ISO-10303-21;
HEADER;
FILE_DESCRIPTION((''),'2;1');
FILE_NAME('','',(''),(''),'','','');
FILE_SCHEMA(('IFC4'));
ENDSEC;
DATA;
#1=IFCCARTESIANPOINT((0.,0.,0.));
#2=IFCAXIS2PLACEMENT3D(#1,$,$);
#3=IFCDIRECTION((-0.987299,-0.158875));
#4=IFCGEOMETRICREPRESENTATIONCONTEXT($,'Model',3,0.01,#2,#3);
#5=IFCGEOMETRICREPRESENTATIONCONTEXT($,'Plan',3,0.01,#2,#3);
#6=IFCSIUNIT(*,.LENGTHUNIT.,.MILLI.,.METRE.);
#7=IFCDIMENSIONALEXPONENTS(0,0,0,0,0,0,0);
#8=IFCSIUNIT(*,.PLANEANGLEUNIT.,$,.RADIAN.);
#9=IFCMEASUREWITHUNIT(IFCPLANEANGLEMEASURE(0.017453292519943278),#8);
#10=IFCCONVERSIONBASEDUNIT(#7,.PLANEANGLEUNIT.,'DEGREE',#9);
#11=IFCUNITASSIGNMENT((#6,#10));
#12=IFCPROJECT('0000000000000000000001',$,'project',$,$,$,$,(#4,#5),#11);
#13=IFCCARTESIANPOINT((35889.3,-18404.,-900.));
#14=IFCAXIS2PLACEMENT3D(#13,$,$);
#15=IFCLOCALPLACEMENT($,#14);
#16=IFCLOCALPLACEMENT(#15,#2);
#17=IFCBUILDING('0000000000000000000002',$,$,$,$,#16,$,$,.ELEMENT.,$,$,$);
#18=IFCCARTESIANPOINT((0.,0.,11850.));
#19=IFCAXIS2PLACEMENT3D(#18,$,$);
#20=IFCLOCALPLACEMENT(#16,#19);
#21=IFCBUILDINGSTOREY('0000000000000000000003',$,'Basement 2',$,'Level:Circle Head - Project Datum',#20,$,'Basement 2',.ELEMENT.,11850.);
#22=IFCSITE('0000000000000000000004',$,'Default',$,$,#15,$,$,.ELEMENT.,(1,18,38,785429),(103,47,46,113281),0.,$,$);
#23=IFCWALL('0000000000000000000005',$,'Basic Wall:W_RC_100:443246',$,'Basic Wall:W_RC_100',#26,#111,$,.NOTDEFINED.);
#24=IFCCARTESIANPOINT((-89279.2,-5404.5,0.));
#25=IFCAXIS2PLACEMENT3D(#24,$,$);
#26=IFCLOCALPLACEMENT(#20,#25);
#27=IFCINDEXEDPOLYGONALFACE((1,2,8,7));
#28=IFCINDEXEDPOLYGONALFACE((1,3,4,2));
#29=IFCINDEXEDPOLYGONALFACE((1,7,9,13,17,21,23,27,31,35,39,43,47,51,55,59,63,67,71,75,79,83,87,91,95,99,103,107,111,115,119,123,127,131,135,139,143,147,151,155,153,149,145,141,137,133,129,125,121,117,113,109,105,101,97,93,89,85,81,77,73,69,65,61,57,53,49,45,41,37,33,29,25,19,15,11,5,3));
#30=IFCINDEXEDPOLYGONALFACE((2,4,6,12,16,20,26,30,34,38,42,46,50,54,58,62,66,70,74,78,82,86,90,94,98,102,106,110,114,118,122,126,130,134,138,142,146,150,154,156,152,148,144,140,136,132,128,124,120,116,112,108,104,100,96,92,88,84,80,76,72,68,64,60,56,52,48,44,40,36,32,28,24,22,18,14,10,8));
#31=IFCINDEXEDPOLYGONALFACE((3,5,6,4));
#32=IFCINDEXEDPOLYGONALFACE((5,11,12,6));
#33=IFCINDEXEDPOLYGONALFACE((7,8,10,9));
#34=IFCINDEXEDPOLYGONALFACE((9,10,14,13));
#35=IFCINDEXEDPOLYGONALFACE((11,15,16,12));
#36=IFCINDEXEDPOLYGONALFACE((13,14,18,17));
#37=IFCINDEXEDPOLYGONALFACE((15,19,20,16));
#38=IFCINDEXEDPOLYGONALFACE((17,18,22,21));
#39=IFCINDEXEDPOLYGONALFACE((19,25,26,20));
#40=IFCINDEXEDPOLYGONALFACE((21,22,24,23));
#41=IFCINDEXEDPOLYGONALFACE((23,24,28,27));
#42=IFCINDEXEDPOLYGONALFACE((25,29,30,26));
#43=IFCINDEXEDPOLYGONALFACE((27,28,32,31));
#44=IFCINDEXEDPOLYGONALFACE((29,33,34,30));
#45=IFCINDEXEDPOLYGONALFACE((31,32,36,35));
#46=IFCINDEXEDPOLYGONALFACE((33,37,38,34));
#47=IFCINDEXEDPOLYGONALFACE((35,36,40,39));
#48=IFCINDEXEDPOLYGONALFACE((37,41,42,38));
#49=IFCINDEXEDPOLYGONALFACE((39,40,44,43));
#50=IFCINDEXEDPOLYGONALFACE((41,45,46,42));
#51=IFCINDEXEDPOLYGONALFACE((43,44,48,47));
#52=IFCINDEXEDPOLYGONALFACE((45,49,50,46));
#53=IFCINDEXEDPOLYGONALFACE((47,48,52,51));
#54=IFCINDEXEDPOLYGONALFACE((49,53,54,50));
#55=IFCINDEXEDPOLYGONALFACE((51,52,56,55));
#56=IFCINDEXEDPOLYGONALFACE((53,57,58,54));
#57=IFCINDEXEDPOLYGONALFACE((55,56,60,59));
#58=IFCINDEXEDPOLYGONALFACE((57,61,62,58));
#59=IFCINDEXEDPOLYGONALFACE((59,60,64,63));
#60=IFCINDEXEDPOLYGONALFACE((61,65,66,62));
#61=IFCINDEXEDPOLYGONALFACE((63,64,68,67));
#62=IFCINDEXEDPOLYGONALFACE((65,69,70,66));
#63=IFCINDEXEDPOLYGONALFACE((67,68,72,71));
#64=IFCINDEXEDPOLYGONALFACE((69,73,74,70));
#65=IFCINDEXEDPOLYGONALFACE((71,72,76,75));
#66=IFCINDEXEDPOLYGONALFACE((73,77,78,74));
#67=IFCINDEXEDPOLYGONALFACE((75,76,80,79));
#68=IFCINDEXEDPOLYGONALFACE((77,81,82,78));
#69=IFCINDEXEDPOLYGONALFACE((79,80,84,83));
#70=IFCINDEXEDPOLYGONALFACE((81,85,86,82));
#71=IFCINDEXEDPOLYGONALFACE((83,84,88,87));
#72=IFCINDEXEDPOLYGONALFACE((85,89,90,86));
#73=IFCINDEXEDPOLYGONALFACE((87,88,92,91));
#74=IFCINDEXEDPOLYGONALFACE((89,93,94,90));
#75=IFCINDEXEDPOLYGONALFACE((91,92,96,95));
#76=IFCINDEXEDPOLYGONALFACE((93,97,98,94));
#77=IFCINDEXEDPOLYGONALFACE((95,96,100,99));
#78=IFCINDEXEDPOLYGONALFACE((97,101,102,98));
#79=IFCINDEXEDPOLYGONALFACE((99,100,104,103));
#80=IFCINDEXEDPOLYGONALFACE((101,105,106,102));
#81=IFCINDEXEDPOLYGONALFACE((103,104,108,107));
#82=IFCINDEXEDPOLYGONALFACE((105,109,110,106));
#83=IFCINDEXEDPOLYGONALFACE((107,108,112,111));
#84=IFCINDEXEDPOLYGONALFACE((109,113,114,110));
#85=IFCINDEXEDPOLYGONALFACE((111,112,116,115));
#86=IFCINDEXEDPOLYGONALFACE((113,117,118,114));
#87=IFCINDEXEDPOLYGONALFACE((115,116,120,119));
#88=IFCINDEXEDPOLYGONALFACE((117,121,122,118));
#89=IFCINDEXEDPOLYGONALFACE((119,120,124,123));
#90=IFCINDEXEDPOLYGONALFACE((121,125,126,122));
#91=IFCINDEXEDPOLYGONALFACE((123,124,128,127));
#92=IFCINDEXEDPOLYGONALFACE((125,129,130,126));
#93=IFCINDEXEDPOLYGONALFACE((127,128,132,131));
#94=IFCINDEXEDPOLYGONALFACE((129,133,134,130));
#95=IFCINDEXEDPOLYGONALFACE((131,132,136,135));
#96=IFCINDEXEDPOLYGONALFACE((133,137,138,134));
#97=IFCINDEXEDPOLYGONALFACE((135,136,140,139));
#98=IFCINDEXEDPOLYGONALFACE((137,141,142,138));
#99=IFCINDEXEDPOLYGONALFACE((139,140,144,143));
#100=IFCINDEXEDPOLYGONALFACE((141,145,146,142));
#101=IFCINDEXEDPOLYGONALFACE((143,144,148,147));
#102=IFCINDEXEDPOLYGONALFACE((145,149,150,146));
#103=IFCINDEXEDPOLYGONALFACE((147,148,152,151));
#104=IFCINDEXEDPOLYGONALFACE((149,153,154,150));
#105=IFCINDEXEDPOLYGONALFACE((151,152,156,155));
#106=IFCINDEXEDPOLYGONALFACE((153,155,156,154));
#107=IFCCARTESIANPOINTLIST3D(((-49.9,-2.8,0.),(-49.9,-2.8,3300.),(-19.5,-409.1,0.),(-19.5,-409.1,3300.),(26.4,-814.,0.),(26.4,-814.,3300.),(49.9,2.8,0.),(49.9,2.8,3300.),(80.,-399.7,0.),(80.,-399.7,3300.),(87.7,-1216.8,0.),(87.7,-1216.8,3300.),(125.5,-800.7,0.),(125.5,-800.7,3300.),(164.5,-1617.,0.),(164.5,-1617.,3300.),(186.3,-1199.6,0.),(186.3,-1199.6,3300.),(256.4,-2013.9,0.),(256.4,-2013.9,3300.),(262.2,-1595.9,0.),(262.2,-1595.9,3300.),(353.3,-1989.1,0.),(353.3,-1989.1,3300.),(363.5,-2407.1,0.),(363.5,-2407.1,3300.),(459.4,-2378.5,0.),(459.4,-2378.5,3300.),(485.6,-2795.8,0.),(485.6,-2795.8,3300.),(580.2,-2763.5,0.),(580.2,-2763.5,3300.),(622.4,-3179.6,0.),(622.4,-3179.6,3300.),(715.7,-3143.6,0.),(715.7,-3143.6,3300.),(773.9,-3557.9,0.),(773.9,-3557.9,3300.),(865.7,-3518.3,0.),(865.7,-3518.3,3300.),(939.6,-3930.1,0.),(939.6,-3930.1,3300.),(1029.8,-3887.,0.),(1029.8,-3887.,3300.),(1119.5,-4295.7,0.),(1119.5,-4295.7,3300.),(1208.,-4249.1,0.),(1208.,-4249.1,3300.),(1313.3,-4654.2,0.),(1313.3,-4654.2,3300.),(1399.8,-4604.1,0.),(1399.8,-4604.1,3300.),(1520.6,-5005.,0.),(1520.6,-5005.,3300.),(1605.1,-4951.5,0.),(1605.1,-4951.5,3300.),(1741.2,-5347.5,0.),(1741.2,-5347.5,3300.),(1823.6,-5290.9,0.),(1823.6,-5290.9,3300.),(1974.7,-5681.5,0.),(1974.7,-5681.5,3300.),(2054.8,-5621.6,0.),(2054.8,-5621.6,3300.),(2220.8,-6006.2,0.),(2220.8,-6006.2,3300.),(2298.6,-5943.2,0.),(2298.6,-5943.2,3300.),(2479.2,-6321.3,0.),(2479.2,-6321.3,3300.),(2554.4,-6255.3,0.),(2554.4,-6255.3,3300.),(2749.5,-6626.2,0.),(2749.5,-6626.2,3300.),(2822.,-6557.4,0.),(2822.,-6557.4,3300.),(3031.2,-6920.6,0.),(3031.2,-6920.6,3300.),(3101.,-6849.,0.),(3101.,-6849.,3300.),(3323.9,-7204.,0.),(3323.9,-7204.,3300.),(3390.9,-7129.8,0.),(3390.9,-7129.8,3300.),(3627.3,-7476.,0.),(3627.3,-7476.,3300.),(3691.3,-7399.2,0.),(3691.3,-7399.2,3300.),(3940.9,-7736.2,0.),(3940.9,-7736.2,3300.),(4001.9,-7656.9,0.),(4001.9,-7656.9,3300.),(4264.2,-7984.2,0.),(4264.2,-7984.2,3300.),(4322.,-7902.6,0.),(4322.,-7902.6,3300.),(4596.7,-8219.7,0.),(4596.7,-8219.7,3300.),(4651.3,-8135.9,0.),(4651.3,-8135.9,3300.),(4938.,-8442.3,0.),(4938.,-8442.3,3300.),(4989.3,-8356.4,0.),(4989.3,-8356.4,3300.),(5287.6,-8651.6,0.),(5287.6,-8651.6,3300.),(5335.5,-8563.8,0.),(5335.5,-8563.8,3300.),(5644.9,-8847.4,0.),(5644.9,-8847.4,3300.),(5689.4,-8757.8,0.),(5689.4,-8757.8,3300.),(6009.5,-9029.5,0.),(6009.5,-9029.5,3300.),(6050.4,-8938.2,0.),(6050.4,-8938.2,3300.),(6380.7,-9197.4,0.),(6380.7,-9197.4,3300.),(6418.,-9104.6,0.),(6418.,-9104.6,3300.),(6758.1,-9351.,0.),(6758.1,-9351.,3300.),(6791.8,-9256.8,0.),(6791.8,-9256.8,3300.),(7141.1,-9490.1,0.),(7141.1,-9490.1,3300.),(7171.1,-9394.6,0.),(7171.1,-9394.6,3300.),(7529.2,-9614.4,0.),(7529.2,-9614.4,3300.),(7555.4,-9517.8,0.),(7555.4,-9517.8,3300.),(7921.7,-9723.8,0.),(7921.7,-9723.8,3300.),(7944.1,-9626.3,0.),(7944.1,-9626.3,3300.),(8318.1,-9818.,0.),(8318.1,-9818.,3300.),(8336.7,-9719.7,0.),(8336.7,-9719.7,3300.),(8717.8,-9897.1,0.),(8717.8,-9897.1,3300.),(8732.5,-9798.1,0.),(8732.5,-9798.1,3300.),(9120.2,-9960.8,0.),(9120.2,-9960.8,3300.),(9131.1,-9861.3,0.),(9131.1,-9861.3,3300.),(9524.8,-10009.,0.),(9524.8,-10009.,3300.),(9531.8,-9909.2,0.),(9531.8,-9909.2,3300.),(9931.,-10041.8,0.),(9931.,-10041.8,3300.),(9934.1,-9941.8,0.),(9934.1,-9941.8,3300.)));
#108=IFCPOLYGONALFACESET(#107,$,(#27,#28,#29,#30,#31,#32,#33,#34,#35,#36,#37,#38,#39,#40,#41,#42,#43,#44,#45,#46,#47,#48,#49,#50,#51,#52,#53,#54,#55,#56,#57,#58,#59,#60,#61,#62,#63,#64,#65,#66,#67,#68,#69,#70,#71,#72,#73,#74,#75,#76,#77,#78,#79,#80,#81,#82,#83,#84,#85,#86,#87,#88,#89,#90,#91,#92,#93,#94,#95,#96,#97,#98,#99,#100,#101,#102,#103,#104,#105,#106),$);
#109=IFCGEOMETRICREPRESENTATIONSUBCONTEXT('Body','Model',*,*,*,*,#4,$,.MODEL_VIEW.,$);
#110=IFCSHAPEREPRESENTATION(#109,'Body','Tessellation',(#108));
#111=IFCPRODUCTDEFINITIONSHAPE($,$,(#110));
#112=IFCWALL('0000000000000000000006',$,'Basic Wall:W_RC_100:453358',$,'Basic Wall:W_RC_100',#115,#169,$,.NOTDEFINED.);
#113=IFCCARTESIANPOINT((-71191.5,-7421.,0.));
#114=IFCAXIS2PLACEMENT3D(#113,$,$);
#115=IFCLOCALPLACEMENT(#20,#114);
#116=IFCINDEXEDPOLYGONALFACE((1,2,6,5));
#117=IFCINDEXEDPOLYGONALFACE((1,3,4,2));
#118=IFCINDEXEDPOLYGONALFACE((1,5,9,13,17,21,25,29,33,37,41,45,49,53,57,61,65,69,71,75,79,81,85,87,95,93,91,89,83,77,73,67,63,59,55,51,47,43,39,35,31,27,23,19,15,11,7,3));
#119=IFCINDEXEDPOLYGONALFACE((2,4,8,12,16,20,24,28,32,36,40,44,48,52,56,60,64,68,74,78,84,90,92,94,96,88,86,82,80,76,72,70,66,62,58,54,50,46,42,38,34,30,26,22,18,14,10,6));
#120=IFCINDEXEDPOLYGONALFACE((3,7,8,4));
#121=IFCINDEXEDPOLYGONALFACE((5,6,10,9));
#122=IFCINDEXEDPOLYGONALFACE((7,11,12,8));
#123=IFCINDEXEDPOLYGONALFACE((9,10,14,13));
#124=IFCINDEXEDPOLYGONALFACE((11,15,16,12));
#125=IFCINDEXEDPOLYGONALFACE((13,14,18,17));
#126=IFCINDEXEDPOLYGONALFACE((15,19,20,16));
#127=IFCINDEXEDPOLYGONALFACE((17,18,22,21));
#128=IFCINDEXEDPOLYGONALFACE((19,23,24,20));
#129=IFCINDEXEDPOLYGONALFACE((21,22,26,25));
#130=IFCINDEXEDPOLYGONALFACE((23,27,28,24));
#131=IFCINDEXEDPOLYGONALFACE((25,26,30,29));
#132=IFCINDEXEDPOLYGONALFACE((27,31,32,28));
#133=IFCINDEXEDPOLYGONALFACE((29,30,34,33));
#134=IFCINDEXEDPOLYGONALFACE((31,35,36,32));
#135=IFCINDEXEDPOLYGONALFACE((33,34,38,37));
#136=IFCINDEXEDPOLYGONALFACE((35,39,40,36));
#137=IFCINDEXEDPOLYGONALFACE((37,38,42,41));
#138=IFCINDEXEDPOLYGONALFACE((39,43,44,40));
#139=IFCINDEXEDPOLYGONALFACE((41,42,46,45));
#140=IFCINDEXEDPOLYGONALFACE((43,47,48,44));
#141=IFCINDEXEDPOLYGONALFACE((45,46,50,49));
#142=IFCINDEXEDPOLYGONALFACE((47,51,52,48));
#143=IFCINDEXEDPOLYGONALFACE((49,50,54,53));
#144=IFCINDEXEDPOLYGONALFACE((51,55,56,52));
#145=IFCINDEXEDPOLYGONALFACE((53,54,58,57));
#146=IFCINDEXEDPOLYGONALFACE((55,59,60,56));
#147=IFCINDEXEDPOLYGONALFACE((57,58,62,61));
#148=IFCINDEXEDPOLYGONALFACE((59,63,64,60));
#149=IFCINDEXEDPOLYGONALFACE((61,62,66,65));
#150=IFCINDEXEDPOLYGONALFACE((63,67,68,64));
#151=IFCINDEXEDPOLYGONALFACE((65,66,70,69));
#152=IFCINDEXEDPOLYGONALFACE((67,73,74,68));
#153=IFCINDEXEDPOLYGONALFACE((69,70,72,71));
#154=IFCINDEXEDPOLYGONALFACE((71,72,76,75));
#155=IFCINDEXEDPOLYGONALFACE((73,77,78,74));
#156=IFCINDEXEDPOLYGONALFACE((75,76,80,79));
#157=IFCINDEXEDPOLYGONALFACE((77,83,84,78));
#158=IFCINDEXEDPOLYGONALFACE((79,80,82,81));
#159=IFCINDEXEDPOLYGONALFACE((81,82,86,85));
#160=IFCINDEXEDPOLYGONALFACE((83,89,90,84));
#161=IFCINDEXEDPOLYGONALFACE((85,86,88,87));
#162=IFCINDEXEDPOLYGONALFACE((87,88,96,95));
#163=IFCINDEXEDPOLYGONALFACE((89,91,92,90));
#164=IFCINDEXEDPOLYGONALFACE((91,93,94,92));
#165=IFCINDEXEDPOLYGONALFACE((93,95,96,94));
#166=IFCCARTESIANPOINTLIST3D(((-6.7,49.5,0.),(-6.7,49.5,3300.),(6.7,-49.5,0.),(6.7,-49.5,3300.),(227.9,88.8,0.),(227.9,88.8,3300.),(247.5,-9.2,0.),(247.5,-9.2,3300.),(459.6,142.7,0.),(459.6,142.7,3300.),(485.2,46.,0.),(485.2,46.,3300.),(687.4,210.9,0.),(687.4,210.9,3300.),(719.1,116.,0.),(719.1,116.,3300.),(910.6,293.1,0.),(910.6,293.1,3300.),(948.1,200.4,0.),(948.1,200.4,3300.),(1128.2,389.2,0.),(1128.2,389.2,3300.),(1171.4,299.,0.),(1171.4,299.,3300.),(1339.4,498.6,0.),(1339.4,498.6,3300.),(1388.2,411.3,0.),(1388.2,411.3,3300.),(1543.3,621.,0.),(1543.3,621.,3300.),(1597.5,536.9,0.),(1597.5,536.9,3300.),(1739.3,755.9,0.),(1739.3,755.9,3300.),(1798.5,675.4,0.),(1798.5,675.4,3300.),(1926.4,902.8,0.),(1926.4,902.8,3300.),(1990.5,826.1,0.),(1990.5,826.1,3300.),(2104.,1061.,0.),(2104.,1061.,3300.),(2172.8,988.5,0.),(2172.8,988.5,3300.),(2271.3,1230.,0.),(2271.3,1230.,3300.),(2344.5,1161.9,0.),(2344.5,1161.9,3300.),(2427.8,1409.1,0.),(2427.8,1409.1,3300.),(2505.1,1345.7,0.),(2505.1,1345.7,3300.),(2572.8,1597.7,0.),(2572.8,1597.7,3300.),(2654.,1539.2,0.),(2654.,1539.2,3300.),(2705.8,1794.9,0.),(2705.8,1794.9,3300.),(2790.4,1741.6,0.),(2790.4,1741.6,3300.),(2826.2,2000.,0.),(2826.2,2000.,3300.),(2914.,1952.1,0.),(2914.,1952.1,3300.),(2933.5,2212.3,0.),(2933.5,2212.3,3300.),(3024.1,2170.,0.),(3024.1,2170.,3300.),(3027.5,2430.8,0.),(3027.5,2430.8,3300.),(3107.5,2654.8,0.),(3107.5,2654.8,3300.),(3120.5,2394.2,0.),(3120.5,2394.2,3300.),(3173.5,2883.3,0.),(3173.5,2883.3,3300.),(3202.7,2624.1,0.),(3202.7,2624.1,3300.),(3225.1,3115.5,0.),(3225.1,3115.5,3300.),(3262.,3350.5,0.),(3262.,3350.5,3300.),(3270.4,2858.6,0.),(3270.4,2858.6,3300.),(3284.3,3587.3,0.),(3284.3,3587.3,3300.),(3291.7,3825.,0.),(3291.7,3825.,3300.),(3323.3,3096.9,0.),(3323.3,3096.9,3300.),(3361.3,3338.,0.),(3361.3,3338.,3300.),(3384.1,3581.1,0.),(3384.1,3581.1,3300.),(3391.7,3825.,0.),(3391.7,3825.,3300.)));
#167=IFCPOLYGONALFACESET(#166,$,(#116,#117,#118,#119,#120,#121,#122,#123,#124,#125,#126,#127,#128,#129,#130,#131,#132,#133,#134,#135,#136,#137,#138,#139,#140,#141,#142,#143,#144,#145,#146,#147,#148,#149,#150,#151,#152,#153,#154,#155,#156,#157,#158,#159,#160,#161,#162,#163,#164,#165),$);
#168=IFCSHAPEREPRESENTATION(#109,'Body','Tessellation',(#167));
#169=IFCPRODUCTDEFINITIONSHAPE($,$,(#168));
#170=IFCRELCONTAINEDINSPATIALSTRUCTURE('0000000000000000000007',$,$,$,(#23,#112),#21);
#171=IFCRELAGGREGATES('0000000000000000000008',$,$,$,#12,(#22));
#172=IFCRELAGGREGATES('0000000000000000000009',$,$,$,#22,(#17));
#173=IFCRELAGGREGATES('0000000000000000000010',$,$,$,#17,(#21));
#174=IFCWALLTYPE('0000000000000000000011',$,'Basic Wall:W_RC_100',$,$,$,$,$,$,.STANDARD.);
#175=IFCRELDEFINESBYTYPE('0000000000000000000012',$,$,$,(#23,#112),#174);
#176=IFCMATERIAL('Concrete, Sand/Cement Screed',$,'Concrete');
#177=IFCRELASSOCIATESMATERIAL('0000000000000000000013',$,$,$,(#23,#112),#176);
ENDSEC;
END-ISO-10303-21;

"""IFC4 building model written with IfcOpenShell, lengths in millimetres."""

from ifc_helpers import new_model, entity, si_unit, converted_unit, direction, frame, origin, place, context, subcontext, project, spatial, line, arc, indexed_curve, outline, extrude, material, type_object, element, save


model = new_model("IFC4")

# Units and contexts
model_context = context("Model", 3, precision=0.01, world=origin(), true_north=direction((-0.987299, -0.158875)))
plan_context = context("Plan", 3, precision=0.01, world=origin(), true_north=direction((-0.987299, -0.158875)))
body_context = subcontext(model_context, "Body", "Model", "MODEL_VIEW")
ifc_project = project(units=[si_unit("LENGTHUNIT", "METRE", prefix="MILLI"), converted_unit("PLANEANGLEUNIT", "DEGREE", entity("IfcPlaneAngleMeasure", 0.017453292519943278), si_unit("PLANEANGLEUNIT", "RADIAN"), dimensions=[0, 0, 0, 0, 0, 0, 0])], contexts=[model_context, plan_context])

# Site, building, storey
site_placement = place(None, frame((35889.3, -18404.0, -900.0)))
site = spatial("IfcSite", under=ifc_project, at=site_placement, Name="Default", CompositionType="ELEMENT", RefLatitude=(1, 18, 38, 785429), RefLongitude=(103, 47, 46, 113281), RefElevation=0.0)
building_placement = place(site_placement, origin())
building = spatial("IfcBuilding", under=site, at=building_placement, CompositionType="ELEMENT")
storey_placement = place(building_placement, frame((0.0, 0.0, 11850.0)))
storey = spatial("IfcBuildingStorey", under=building, at=storey_placement, Name="Basement 2", ObjectType="Level:Circle Head - Project Datum", LongName="Basement 2", CompositionType="ELEMENT", Elevation=11850.0)

# Walls
ifc_material_1 = material(Name="Concrete, Sand/Cement Screed", Category="Concrete")
wall_type_1 = type_object("IfcWallType", Name="Basic Wall:W_RC_100", PredefinedType="STANDARD")
wall_1_placement = place(storey_placement, frame((-89279.2, -5404.5, 0.0)))
element("IfcWall", 1, at=wall_1_placement, inside=storey, type_object=wall_type_1, material=ifc_material_1, Name="Basic Wall:W_RC_100:443246", ObjectType="Basic Wall:W_RC_100", PredefinedType="NOTDEFINED", context=body_context, shape_type="SweptSolid", body=[
    extrude(outline(indexed_curve([(9934.1, -9941.8), (3101.0, -6849.0), (49.9, 2.8), (-49.9, -2.8), (3031.2, -6920.6), (9931.0, -10041.8)], segments=[arc(1, 2, 3), line(3, 4), arc(4, 5, 6), line(6, 1)], self_intersect=False)), origin(), (0.0, 0.0, 1.0), 3300.0),
])
wall_2_placement = place(storey_placement, frame((-71191.5, -7421.0, 0.0)))
element("IfcWall", 2, at=wall_2_placement, inside=storey, type_object=wall_type_1, material=ifc_material_1, Name="Basic Wall:W_RC_100:453358", ObjectType="Basic Wall:W_RC_100", PredefinedType="NOTDEFINED", context=body_context, shape_type="SweptSolid", body=[
    extrude(outline(indexed_curve([(3291.7, 3825.0), (2351.0, 1318.4), (-6.7, 49.5), (6.7, -49.5), (2426.3, 1252.6), (3391.7, 3825.0)], segments=[arc(1, 2, 3), line(3, 4), arc(4, 5, 6), line(6, 1)], self_intersect=False)), origin(), (0.0, 0.0, 1.0), 3300.0),
])

save(model, "model.ifc")
